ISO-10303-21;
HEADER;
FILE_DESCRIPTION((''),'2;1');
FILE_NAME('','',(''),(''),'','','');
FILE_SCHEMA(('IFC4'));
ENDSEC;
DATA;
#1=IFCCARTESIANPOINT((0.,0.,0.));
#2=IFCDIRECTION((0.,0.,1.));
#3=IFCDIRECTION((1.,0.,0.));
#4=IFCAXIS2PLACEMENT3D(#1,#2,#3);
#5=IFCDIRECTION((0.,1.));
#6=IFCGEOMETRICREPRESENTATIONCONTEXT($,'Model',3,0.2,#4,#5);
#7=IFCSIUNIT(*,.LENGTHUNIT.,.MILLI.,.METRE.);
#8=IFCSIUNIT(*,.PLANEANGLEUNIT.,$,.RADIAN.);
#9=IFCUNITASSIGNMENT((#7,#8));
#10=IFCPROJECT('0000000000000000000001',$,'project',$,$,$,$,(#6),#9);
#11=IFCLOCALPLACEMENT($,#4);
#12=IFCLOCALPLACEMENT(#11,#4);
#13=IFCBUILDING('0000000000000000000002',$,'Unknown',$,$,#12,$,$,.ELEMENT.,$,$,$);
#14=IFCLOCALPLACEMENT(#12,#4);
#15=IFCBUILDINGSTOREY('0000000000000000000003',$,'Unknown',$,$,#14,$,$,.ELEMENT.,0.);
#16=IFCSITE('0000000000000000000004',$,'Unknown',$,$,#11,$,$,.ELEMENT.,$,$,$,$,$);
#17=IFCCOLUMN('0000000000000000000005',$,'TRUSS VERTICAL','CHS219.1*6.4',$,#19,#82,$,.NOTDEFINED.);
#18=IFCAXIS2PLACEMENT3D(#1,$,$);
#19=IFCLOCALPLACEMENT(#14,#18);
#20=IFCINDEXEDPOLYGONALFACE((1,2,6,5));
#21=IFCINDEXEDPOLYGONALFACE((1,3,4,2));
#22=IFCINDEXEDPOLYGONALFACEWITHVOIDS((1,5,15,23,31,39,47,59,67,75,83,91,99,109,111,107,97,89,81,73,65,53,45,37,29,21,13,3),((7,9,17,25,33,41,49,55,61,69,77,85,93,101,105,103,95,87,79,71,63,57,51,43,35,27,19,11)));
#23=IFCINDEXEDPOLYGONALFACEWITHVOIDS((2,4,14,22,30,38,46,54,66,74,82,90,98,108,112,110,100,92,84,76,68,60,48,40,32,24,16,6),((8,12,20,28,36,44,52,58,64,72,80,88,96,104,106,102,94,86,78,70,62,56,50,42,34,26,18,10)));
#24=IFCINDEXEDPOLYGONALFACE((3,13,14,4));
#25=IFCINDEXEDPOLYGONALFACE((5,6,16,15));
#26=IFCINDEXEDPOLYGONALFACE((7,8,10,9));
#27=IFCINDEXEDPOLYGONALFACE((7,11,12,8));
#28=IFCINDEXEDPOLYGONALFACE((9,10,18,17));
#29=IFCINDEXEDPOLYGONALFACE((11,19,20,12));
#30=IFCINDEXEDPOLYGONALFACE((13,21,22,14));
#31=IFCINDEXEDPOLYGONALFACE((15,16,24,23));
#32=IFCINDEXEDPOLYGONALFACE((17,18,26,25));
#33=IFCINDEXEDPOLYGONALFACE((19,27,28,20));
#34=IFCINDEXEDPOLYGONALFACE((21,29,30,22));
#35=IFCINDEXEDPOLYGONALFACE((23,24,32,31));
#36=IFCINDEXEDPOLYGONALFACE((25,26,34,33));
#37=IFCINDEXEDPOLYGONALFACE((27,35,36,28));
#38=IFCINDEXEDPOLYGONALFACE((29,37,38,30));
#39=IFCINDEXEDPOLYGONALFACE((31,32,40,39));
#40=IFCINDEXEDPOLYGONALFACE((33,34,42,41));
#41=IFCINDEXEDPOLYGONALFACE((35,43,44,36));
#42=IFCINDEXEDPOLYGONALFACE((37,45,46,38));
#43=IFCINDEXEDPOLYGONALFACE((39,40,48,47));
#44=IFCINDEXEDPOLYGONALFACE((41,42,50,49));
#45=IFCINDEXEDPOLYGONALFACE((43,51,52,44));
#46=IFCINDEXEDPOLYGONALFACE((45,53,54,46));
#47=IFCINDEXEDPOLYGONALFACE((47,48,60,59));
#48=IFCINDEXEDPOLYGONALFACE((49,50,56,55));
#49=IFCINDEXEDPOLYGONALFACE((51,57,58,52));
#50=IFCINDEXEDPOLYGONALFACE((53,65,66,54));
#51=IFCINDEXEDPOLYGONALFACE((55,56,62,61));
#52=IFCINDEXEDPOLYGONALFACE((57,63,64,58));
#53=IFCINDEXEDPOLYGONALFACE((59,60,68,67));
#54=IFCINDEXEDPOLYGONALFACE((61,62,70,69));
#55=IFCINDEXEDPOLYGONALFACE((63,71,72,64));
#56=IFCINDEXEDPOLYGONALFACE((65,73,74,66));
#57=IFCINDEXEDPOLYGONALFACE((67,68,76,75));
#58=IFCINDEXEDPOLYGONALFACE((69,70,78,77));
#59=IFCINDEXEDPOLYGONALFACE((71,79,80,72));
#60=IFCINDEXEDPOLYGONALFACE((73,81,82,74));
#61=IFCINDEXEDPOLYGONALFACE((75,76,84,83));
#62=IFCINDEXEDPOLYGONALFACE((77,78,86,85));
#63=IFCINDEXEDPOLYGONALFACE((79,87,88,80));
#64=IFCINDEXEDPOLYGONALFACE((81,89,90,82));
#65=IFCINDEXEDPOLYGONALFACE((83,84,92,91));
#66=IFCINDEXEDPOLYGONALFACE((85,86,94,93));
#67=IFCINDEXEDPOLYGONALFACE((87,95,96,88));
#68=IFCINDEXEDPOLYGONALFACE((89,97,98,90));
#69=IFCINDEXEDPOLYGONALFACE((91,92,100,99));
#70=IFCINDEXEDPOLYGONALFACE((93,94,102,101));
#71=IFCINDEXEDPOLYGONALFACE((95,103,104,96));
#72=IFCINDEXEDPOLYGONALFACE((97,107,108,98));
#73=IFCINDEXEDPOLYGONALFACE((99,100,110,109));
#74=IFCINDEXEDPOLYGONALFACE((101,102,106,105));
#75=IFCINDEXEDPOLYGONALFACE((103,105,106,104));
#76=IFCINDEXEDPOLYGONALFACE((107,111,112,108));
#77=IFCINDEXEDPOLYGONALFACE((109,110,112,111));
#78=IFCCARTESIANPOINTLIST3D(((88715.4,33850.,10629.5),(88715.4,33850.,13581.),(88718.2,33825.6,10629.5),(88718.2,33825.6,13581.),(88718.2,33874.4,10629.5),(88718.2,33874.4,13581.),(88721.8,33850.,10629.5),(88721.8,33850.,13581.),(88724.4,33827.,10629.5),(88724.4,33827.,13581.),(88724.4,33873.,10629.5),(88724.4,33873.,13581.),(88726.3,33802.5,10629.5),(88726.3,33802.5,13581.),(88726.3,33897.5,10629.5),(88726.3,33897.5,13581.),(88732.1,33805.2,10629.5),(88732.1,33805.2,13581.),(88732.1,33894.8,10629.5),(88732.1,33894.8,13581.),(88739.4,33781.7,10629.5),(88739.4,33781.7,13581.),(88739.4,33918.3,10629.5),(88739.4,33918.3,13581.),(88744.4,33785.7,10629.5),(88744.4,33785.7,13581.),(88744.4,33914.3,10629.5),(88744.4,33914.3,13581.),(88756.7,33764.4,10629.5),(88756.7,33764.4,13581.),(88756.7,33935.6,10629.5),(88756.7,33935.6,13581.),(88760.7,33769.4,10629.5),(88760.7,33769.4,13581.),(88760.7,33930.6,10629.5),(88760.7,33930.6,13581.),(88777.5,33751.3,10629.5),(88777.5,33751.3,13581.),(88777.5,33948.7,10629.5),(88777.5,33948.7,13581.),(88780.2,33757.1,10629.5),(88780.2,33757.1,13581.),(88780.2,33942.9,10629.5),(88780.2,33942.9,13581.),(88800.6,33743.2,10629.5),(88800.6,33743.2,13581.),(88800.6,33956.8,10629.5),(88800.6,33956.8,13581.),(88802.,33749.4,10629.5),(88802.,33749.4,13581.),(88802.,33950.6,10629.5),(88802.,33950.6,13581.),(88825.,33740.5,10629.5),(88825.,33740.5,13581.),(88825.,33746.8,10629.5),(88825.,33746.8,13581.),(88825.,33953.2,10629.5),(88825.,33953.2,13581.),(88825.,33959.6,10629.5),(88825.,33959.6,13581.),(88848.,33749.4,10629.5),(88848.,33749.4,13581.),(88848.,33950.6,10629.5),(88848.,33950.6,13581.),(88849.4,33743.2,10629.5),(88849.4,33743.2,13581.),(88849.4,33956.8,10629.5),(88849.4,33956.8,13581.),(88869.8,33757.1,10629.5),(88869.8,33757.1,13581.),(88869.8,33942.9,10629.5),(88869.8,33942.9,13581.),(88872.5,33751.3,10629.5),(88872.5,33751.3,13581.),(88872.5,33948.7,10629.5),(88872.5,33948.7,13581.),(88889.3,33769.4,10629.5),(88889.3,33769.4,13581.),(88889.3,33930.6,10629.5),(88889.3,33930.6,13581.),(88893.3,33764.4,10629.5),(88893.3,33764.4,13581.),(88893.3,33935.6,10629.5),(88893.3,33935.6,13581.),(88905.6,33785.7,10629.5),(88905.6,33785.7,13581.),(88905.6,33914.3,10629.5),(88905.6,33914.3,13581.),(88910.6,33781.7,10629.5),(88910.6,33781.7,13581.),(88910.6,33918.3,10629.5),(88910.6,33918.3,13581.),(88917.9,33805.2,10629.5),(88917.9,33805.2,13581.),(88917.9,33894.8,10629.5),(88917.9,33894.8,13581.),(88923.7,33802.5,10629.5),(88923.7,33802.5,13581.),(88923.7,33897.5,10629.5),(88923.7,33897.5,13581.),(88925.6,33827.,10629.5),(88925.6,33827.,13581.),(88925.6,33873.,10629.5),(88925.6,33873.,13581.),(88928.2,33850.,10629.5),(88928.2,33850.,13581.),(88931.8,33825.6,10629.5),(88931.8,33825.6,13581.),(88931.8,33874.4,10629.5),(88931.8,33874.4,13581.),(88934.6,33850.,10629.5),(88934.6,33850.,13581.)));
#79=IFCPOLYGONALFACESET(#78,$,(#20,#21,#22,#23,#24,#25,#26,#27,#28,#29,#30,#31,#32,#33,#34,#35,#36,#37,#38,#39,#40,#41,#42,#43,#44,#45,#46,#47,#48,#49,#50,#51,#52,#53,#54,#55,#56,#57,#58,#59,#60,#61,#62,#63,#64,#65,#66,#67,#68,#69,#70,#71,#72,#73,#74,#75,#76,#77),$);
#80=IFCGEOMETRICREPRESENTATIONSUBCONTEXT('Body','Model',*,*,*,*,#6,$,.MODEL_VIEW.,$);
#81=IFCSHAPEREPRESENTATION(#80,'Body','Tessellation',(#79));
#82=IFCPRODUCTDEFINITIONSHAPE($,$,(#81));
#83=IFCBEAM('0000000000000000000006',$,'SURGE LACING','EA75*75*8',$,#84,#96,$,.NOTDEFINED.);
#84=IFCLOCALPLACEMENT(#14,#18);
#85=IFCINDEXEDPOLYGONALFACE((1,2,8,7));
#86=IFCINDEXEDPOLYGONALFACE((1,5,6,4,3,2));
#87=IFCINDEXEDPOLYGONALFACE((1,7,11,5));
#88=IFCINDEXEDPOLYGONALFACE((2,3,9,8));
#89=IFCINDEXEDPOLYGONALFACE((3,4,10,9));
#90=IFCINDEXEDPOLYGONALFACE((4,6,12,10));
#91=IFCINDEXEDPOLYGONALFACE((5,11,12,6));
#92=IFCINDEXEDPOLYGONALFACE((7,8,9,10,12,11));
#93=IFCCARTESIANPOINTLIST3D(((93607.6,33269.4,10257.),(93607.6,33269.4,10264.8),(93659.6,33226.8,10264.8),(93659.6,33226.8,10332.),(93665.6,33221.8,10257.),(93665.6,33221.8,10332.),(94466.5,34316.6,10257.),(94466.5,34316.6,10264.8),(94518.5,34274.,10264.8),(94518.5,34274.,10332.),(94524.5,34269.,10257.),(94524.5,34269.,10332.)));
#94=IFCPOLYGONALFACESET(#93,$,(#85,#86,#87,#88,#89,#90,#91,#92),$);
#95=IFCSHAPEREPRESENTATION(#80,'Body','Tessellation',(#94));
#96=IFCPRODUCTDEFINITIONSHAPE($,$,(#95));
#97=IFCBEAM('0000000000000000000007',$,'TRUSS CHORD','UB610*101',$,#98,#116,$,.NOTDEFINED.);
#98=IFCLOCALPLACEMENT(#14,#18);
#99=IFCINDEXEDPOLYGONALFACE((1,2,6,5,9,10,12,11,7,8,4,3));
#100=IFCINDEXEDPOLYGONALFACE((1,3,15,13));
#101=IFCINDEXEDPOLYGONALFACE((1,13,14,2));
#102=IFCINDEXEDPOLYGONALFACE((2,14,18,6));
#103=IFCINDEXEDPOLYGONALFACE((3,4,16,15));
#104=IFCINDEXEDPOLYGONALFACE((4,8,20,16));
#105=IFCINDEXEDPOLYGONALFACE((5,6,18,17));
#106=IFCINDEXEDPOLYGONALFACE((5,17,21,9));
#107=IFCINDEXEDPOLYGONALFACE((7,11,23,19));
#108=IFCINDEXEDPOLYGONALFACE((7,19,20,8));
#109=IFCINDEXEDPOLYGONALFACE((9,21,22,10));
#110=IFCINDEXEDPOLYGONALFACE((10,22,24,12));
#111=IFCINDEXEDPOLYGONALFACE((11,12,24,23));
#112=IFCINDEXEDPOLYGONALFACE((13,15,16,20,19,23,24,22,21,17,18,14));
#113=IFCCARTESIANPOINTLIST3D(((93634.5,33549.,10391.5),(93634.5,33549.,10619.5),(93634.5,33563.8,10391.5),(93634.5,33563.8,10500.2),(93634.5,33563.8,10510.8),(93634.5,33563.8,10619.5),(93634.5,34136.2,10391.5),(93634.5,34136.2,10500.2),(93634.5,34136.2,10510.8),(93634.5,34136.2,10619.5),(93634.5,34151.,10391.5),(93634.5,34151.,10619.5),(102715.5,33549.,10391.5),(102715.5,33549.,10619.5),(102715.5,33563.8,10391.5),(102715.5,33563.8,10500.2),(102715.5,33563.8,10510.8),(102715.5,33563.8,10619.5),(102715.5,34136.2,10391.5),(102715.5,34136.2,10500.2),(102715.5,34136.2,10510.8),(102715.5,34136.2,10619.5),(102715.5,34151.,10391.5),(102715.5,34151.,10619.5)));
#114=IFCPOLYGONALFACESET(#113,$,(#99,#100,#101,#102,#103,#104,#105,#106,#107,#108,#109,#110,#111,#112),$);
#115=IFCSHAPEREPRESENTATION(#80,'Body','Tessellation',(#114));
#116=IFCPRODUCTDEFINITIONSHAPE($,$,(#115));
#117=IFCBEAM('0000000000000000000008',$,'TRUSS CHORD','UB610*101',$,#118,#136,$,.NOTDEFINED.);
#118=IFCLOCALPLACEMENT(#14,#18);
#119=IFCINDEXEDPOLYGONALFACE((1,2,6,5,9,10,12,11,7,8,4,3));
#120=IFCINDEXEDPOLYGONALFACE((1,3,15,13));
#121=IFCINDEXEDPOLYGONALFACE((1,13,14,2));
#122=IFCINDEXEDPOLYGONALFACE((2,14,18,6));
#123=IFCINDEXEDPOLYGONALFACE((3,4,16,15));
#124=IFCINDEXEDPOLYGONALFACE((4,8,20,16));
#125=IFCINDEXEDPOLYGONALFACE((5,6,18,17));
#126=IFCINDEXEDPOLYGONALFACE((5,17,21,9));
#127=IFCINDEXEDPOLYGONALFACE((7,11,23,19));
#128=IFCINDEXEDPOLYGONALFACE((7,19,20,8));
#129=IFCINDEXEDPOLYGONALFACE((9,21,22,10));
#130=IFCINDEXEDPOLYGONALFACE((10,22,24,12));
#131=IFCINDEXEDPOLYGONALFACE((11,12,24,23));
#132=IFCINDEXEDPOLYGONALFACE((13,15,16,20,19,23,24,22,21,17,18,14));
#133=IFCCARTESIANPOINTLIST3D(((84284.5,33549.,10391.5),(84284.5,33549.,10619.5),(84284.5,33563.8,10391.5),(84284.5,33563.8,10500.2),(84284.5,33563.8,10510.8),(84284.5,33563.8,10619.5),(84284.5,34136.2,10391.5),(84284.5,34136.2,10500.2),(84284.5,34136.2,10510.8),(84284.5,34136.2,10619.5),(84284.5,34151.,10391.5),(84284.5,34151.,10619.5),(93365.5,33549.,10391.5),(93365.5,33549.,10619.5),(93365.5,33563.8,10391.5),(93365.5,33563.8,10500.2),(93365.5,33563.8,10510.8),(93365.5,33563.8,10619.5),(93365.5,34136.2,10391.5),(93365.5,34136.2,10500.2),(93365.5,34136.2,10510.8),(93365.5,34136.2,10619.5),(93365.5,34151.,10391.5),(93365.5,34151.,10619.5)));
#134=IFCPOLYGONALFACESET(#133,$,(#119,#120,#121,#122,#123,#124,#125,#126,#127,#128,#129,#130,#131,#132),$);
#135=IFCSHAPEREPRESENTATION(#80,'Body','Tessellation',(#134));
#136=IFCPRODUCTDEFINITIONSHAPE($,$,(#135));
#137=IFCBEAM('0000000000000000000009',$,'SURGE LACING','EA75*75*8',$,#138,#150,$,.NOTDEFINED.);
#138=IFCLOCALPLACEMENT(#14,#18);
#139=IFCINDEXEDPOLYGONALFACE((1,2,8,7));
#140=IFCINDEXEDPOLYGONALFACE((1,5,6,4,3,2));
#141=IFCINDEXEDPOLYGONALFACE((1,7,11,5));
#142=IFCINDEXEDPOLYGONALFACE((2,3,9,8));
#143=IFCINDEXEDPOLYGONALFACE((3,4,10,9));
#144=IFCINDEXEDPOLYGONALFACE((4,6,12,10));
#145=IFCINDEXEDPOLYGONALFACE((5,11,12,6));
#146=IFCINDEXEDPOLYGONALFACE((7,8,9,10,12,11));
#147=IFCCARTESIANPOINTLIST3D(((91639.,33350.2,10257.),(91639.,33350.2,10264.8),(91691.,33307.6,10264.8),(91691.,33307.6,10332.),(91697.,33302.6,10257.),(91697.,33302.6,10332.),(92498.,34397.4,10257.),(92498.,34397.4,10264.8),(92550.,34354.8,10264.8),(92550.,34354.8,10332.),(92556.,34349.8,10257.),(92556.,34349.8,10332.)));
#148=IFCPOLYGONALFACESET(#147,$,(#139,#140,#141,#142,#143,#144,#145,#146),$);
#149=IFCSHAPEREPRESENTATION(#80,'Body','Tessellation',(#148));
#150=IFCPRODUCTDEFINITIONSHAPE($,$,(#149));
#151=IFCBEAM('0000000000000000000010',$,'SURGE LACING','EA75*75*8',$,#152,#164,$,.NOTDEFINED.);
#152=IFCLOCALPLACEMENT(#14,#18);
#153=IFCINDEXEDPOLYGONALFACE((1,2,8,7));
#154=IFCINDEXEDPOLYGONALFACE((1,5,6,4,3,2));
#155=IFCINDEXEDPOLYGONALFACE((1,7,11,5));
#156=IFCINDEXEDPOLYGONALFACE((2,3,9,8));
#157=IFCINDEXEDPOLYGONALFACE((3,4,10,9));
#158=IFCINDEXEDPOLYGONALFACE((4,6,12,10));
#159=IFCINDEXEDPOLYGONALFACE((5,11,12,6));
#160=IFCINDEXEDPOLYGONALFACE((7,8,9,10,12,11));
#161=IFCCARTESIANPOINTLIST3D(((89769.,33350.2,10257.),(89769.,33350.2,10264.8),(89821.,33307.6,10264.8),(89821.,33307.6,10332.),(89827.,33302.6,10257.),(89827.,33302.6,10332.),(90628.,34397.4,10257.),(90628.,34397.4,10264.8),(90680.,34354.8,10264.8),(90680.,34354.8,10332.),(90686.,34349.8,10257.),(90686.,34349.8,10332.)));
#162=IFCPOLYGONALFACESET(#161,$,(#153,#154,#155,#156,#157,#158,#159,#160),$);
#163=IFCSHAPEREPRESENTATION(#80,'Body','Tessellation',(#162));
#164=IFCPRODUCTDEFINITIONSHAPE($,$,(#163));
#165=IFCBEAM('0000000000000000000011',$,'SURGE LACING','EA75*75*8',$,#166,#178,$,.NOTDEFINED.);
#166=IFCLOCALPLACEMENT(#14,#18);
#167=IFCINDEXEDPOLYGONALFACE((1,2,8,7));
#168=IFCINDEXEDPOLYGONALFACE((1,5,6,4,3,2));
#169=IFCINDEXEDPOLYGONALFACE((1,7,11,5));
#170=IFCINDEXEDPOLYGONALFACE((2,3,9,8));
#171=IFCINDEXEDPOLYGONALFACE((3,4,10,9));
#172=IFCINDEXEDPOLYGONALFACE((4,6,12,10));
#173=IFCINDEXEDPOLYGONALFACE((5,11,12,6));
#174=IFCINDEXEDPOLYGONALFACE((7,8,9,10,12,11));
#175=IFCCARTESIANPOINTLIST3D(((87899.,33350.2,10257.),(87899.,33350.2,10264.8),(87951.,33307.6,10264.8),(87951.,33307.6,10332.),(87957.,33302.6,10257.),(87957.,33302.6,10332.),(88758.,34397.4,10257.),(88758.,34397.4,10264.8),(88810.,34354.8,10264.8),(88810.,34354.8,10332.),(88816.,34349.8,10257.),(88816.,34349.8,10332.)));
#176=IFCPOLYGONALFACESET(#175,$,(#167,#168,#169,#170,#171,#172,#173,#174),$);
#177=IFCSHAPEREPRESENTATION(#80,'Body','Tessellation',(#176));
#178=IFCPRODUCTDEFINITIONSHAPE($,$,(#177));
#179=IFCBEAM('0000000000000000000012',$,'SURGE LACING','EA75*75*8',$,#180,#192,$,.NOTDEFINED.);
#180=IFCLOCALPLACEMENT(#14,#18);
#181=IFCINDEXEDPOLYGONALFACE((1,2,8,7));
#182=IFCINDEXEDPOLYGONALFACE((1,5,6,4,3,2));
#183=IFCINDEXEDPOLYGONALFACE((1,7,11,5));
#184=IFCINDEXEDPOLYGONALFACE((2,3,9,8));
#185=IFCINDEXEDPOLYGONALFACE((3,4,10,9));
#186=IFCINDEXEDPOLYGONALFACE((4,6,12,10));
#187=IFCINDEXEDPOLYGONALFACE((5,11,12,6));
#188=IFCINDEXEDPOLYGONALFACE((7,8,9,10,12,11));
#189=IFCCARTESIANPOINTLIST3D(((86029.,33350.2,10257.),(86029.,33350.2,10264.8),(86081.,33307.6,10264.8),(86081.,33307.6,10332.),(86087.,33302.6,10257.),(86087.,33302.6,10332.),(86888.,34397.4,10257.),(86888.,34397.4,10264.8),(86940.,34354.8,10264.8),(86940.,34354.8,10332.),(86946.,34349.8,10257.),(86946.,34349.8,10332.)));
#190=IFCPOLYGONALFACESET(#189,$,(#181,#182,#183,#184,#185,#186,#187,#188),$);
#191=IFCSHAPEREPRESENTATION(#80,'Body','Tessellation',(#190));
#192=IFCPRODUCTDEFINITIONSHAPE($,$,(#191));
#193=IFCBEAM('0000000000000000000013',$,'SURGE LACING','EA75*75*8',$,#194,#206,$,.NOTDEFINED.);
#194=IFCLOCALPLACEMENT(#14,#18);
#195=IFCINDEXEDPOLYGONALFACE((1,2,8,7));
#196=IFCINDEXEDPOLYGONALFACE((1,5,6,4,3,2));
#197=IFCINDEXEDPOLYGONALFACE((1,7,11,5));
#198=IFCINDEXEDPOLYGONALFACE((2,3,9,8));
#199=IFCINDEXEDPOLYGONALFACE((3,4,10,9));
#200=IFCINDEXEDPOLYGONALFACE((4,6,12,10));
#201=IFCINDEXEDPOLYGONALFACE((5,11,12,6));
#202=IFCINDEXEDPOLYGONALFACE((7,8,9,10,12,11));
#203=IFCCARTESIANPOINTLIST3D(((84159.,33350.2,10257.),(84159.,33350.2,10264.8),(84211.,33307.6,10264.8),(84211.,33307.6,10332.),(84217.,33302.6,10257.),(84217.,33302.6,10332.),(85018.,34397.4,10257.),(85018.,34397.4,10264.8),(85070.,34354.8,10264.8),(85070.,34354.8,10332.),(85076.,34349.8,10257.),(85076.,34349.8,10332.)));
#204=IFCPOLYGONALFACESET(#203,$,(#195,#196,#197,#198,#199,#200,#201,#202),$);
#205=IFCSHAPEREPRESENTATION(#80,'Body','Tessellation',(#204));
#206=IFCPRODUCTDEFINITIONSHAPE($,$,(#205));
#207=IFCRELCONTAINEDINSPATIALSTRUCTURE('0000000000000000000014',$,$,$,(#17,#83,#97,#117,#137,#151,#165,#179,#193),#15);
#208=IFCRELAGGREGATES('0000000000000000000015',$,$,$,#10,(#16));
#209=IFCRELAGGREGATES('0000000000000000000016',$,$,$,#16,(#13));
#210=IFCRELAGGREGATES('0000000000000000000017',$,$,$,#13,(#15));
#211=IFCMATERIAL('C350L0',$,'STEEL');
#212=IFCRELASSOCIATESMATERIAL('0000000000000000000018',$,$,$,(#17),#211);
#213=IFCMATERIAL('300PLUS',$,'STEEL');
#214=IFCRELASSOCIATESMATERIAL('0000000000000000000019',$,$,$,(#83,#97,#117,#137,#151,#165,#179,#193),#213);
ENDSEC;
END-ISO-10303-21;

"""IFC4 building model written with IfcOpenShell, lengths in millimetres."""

from ifc_helpers import new_model, si_unit, direction, frame, origin_with_axes, place, context, subcontext, project, spatial, line, indexed_curve, outline, extrude, material, element, save


model = new_model("IFC4")

# Units and contexts
model_context = context("Model", 3, precision=0.2, world=origin_with_axes(), true_north=direction((0.0, 1.0)))
body_context = subcontext(model_context, "Body", "Model", "MODEL_VIEW")
ifc_project = project(units=[si_unit("LENGTHUNIT", "METRE", prefix="MILLI"), si_unit("PLANEANGLEUNIT", "RADIAN")], contexts=[model_context])

# Site, building, storey
site_placement = place(None, origin_with_axes())
site = spatial("IfcSite", under=ifc_project, at=site_placement, Name="Unknown", CompositionType="ELEMENT")
building_placement = place(site_placement, origin_with_axes())
building = spatial("IfcBuilding", under=site, at=building_placement, Name="Unknown", CompositionType="ELEMENT")
storey_placement = place(building_placement, origin_with_axes())
storey = spatial("IfcBuildingStorey", under=building, at=storey_placement, Name="Unknown", CompositionType="ELEMENT", Elevation=0.0)

# Column
ifc_material_1 = material(Name="C350L0", Category="STEEL")
column_placement = place(storey_placement, frame((88825.0, 33850.0, 10629.5), z_axis=(-1.0, 0.0, 0.0), x_axis=(0.0, 0.0, 1.0)))
element("IfcColumn", 1, at=column_placement, inside=storey, material=ifc_material_1, Name="TRUSS VERTICAL", Description="CHS219.1*6.4", PredefinedType="NOTDEFINED", context=body_context, shape_type="SolidModel", body=[
    extrude(outline(indexed_curve([(109.5, 0.0), (106.8, 24.4), (98.7, 47.5), (85.6, 68.3), (68.3, 85.6), (47.5, 98.7), (24.4, 106.8), (0.0, 109.5), (-24.4, 106.8), (-47.5, 98.7), (-68.3, 85.6), (-85.6, 68.3), (-98.7, 47.5), (-106.8, 24.4), (-109.5, 0.0), (-106.8, -24.4), (-98.7, -47.5), (-85.6, -68.3), (-68.3, -85.6), (-47.5, -98.7), (-24.4, -106.8), (0.0, -109.5), (24.4, -106.8), (47.5, -98.7), (68.3, -85.6), (85.6, -68.3), (98.7, -47.5), (106.8, -24.4)], segments=[line(1, 2, 3, 4, 5, 6, 7, 8, 9, 10, 11, 12, 13, 14, 15, 16, 17, 18, 19, 20, 21, 22, 23, 24, 25, 26, 27, 28, 1)]), holes=[indexed_curve([(103.2, 0.0), (100.6, -23.0), (92.9, -44.8), (80.6, -64.3), (64.3, -80.6), (44.8, -92.9), (23.0, -100.6), (0.0, -103.2), (-23.0, -100.6), (-44.8, -92.9), (-64.3, -80.6), (-80.6, -64.3), (-92.9, -44.8), (-100.6, -23.0), (-103.2, 0.0), (-100.6, 23.0), (-92.9, 44.8), (-80.6, 64.3), (-64.3, 80.6), (-44.8, 92.9), (-23.0, 100.6), (0.0, 103.2), (23.0, 100.6), (44.8, 92.9), (64.3, 80.6), (80.6, 64.3), (92.9, 44.8), (100.6, 23.0)], segments=[line(1, 2, 3, 4, 5, 6, 7, 8, 9, 10, 11, 12, 13, 14, 15, 16, 17, 18, 19, 20, 21, 22, 23, 24, 25, 26, 27, 28, 1)])]), frame((0.0, 0.0, 0.0), z_axis=(-1.0, 0.0, 0.0), x_axis=(0.0, 0.0, 1.0)), (0.0, 0.0, -1.0), 2951.5),
])

# Beams
ifc_material_2 = material(Name="300PLUS", Category="STEEL")
beam_placement = place(storey_placement, frame((93636.6, 33245.6, 10294.5), z_axis=(0.0, 0.0, 1.0), x_axis=(0.634166, 0.773197, 0.0)))
element("IfcBeam", 2, at=beam_placement, inside=storey, material=ifc_material_2, Name="SURGE LACING", Description="EA75*75*8", PredefinedType="NOTDEFINED", context=body_context, shape_type="SolidModel", body=[
    extrude(outline(indexed_curve([(-37.5, -37.5), (37.5, -37.5), (37.5, -29.7), (-29.7, -29.7), (-29.7, 37.5), (-37.5, 37.5)], segments=[line(1, 2, 3, 4, 5, 6, 1)])), frame((0.0, 0.0, 0.0), z_axis=(-1.0, 0.0, 0.0), x_axis=(0.0, 0.0, 1.0)), (0.0, 0.0, -1.0), 1354.4),
])
for number, where, z_axis, x_axis, name in (
    (3, (93634.5, 33850.0, 10505.5), (0.0, 0.0, 1.0), (1.0, 0.0, 0.0), "TRUSS CHORD"),
    (4, (84284.5, 33850.0, 10505.5), (0.0, 0.0, 1.0), (1.0, 0.0, 0.0), "TRUSS CHORD"),
):
    element("IfcBeam", number, at=place(storey_placement, frame(where, z_axis=z_axis, x_axis=x_axis)), inside=storey, material=ifc_material_2, Name=name, Description="UB610*101", PredefinedType="NOTDEFINED", context=body_context, shape_type="SolidModel", body=[
        extrude(outline(indexed_curve([(-114.0, -301.0), (114.0, -301.0), (114.0, -286.2), (5.3, -286.2), (5.3, 286.2), (114.0, 286.2), (114.0, 301.0), (-114.0, 301.0), (-114.0, 286.2), (-5.3, 286.2), (-5.3, -286.2), (-114.0, -286.2)], segments=[line(1, 2, 3, 4, 5, 6, 7, 8, 9, 10, 11, 12, 1)])), frame((0.0, 0.0, 0.0), z_axis=(-1.0, 0.0, 0.0), x_axis=(0.0, 0.0, 1.0)), (0.0, 0.0, -1.0), 9081.0),
    ])
for number, where, z_axis, x_axis, name in (
    (5, (91668.0, 33326.4, 10294.5), (0.0, 0.0, 1.0), (0.63421, 0.773161, 0.0), "SURGE LACING"),
    (6, (89798.0, 33326.4, 10294.5), (0.0, 0.0, 1.0), (0.63421, 0.773161, 0.0), "SURGE LACING"),
    (7, (87928.0, 33326.4, 10294.5), (0.0, 0.0, 1.0), (0.63421, 0.773161, 0.0), "SURGE LACING"),
    (8, (86058.0, 33326.4, 10294.5), (0.0, 0.0, 1.0), (0.63421, 0.773161, 0.0), "SURGE LACING"),
    (9, (84188.0, 33326.4, 10294.5), (0.0, 0.0, 1.0), (0.63421, 0.773161, 0.0), "SURGE LACING"),
):
    element("IfcBeam", number, at=place(storey_placement, frame(where, z_axis=z_axis, x_axis=x_axis)), inside=storey, material=ifc_material_2, Name=name, Description="EA75*75*8", PredefinedType="NOTDEFINED", context=body_context, shape_type="SolidModel", body=[
        extrude(outline(indexed_curve([(-37.5, -37.5), (37.5, -37.5), (37.5, -29.7), (-29.7, -29.7), (-29.7, 37.5), (-37.5, 37.5)], segments=[line(1, 2, 3, 4, 5, 6, 1)])), frame((0.0, 0.0, 0.0), z_axis=(-1.0, 0.0, 0.0), x_axis=(0.0, 0.0, 1.0)), (0.0, 0.0, -1.0), 1354.4),
    ])

save(model, "model.ifc")
